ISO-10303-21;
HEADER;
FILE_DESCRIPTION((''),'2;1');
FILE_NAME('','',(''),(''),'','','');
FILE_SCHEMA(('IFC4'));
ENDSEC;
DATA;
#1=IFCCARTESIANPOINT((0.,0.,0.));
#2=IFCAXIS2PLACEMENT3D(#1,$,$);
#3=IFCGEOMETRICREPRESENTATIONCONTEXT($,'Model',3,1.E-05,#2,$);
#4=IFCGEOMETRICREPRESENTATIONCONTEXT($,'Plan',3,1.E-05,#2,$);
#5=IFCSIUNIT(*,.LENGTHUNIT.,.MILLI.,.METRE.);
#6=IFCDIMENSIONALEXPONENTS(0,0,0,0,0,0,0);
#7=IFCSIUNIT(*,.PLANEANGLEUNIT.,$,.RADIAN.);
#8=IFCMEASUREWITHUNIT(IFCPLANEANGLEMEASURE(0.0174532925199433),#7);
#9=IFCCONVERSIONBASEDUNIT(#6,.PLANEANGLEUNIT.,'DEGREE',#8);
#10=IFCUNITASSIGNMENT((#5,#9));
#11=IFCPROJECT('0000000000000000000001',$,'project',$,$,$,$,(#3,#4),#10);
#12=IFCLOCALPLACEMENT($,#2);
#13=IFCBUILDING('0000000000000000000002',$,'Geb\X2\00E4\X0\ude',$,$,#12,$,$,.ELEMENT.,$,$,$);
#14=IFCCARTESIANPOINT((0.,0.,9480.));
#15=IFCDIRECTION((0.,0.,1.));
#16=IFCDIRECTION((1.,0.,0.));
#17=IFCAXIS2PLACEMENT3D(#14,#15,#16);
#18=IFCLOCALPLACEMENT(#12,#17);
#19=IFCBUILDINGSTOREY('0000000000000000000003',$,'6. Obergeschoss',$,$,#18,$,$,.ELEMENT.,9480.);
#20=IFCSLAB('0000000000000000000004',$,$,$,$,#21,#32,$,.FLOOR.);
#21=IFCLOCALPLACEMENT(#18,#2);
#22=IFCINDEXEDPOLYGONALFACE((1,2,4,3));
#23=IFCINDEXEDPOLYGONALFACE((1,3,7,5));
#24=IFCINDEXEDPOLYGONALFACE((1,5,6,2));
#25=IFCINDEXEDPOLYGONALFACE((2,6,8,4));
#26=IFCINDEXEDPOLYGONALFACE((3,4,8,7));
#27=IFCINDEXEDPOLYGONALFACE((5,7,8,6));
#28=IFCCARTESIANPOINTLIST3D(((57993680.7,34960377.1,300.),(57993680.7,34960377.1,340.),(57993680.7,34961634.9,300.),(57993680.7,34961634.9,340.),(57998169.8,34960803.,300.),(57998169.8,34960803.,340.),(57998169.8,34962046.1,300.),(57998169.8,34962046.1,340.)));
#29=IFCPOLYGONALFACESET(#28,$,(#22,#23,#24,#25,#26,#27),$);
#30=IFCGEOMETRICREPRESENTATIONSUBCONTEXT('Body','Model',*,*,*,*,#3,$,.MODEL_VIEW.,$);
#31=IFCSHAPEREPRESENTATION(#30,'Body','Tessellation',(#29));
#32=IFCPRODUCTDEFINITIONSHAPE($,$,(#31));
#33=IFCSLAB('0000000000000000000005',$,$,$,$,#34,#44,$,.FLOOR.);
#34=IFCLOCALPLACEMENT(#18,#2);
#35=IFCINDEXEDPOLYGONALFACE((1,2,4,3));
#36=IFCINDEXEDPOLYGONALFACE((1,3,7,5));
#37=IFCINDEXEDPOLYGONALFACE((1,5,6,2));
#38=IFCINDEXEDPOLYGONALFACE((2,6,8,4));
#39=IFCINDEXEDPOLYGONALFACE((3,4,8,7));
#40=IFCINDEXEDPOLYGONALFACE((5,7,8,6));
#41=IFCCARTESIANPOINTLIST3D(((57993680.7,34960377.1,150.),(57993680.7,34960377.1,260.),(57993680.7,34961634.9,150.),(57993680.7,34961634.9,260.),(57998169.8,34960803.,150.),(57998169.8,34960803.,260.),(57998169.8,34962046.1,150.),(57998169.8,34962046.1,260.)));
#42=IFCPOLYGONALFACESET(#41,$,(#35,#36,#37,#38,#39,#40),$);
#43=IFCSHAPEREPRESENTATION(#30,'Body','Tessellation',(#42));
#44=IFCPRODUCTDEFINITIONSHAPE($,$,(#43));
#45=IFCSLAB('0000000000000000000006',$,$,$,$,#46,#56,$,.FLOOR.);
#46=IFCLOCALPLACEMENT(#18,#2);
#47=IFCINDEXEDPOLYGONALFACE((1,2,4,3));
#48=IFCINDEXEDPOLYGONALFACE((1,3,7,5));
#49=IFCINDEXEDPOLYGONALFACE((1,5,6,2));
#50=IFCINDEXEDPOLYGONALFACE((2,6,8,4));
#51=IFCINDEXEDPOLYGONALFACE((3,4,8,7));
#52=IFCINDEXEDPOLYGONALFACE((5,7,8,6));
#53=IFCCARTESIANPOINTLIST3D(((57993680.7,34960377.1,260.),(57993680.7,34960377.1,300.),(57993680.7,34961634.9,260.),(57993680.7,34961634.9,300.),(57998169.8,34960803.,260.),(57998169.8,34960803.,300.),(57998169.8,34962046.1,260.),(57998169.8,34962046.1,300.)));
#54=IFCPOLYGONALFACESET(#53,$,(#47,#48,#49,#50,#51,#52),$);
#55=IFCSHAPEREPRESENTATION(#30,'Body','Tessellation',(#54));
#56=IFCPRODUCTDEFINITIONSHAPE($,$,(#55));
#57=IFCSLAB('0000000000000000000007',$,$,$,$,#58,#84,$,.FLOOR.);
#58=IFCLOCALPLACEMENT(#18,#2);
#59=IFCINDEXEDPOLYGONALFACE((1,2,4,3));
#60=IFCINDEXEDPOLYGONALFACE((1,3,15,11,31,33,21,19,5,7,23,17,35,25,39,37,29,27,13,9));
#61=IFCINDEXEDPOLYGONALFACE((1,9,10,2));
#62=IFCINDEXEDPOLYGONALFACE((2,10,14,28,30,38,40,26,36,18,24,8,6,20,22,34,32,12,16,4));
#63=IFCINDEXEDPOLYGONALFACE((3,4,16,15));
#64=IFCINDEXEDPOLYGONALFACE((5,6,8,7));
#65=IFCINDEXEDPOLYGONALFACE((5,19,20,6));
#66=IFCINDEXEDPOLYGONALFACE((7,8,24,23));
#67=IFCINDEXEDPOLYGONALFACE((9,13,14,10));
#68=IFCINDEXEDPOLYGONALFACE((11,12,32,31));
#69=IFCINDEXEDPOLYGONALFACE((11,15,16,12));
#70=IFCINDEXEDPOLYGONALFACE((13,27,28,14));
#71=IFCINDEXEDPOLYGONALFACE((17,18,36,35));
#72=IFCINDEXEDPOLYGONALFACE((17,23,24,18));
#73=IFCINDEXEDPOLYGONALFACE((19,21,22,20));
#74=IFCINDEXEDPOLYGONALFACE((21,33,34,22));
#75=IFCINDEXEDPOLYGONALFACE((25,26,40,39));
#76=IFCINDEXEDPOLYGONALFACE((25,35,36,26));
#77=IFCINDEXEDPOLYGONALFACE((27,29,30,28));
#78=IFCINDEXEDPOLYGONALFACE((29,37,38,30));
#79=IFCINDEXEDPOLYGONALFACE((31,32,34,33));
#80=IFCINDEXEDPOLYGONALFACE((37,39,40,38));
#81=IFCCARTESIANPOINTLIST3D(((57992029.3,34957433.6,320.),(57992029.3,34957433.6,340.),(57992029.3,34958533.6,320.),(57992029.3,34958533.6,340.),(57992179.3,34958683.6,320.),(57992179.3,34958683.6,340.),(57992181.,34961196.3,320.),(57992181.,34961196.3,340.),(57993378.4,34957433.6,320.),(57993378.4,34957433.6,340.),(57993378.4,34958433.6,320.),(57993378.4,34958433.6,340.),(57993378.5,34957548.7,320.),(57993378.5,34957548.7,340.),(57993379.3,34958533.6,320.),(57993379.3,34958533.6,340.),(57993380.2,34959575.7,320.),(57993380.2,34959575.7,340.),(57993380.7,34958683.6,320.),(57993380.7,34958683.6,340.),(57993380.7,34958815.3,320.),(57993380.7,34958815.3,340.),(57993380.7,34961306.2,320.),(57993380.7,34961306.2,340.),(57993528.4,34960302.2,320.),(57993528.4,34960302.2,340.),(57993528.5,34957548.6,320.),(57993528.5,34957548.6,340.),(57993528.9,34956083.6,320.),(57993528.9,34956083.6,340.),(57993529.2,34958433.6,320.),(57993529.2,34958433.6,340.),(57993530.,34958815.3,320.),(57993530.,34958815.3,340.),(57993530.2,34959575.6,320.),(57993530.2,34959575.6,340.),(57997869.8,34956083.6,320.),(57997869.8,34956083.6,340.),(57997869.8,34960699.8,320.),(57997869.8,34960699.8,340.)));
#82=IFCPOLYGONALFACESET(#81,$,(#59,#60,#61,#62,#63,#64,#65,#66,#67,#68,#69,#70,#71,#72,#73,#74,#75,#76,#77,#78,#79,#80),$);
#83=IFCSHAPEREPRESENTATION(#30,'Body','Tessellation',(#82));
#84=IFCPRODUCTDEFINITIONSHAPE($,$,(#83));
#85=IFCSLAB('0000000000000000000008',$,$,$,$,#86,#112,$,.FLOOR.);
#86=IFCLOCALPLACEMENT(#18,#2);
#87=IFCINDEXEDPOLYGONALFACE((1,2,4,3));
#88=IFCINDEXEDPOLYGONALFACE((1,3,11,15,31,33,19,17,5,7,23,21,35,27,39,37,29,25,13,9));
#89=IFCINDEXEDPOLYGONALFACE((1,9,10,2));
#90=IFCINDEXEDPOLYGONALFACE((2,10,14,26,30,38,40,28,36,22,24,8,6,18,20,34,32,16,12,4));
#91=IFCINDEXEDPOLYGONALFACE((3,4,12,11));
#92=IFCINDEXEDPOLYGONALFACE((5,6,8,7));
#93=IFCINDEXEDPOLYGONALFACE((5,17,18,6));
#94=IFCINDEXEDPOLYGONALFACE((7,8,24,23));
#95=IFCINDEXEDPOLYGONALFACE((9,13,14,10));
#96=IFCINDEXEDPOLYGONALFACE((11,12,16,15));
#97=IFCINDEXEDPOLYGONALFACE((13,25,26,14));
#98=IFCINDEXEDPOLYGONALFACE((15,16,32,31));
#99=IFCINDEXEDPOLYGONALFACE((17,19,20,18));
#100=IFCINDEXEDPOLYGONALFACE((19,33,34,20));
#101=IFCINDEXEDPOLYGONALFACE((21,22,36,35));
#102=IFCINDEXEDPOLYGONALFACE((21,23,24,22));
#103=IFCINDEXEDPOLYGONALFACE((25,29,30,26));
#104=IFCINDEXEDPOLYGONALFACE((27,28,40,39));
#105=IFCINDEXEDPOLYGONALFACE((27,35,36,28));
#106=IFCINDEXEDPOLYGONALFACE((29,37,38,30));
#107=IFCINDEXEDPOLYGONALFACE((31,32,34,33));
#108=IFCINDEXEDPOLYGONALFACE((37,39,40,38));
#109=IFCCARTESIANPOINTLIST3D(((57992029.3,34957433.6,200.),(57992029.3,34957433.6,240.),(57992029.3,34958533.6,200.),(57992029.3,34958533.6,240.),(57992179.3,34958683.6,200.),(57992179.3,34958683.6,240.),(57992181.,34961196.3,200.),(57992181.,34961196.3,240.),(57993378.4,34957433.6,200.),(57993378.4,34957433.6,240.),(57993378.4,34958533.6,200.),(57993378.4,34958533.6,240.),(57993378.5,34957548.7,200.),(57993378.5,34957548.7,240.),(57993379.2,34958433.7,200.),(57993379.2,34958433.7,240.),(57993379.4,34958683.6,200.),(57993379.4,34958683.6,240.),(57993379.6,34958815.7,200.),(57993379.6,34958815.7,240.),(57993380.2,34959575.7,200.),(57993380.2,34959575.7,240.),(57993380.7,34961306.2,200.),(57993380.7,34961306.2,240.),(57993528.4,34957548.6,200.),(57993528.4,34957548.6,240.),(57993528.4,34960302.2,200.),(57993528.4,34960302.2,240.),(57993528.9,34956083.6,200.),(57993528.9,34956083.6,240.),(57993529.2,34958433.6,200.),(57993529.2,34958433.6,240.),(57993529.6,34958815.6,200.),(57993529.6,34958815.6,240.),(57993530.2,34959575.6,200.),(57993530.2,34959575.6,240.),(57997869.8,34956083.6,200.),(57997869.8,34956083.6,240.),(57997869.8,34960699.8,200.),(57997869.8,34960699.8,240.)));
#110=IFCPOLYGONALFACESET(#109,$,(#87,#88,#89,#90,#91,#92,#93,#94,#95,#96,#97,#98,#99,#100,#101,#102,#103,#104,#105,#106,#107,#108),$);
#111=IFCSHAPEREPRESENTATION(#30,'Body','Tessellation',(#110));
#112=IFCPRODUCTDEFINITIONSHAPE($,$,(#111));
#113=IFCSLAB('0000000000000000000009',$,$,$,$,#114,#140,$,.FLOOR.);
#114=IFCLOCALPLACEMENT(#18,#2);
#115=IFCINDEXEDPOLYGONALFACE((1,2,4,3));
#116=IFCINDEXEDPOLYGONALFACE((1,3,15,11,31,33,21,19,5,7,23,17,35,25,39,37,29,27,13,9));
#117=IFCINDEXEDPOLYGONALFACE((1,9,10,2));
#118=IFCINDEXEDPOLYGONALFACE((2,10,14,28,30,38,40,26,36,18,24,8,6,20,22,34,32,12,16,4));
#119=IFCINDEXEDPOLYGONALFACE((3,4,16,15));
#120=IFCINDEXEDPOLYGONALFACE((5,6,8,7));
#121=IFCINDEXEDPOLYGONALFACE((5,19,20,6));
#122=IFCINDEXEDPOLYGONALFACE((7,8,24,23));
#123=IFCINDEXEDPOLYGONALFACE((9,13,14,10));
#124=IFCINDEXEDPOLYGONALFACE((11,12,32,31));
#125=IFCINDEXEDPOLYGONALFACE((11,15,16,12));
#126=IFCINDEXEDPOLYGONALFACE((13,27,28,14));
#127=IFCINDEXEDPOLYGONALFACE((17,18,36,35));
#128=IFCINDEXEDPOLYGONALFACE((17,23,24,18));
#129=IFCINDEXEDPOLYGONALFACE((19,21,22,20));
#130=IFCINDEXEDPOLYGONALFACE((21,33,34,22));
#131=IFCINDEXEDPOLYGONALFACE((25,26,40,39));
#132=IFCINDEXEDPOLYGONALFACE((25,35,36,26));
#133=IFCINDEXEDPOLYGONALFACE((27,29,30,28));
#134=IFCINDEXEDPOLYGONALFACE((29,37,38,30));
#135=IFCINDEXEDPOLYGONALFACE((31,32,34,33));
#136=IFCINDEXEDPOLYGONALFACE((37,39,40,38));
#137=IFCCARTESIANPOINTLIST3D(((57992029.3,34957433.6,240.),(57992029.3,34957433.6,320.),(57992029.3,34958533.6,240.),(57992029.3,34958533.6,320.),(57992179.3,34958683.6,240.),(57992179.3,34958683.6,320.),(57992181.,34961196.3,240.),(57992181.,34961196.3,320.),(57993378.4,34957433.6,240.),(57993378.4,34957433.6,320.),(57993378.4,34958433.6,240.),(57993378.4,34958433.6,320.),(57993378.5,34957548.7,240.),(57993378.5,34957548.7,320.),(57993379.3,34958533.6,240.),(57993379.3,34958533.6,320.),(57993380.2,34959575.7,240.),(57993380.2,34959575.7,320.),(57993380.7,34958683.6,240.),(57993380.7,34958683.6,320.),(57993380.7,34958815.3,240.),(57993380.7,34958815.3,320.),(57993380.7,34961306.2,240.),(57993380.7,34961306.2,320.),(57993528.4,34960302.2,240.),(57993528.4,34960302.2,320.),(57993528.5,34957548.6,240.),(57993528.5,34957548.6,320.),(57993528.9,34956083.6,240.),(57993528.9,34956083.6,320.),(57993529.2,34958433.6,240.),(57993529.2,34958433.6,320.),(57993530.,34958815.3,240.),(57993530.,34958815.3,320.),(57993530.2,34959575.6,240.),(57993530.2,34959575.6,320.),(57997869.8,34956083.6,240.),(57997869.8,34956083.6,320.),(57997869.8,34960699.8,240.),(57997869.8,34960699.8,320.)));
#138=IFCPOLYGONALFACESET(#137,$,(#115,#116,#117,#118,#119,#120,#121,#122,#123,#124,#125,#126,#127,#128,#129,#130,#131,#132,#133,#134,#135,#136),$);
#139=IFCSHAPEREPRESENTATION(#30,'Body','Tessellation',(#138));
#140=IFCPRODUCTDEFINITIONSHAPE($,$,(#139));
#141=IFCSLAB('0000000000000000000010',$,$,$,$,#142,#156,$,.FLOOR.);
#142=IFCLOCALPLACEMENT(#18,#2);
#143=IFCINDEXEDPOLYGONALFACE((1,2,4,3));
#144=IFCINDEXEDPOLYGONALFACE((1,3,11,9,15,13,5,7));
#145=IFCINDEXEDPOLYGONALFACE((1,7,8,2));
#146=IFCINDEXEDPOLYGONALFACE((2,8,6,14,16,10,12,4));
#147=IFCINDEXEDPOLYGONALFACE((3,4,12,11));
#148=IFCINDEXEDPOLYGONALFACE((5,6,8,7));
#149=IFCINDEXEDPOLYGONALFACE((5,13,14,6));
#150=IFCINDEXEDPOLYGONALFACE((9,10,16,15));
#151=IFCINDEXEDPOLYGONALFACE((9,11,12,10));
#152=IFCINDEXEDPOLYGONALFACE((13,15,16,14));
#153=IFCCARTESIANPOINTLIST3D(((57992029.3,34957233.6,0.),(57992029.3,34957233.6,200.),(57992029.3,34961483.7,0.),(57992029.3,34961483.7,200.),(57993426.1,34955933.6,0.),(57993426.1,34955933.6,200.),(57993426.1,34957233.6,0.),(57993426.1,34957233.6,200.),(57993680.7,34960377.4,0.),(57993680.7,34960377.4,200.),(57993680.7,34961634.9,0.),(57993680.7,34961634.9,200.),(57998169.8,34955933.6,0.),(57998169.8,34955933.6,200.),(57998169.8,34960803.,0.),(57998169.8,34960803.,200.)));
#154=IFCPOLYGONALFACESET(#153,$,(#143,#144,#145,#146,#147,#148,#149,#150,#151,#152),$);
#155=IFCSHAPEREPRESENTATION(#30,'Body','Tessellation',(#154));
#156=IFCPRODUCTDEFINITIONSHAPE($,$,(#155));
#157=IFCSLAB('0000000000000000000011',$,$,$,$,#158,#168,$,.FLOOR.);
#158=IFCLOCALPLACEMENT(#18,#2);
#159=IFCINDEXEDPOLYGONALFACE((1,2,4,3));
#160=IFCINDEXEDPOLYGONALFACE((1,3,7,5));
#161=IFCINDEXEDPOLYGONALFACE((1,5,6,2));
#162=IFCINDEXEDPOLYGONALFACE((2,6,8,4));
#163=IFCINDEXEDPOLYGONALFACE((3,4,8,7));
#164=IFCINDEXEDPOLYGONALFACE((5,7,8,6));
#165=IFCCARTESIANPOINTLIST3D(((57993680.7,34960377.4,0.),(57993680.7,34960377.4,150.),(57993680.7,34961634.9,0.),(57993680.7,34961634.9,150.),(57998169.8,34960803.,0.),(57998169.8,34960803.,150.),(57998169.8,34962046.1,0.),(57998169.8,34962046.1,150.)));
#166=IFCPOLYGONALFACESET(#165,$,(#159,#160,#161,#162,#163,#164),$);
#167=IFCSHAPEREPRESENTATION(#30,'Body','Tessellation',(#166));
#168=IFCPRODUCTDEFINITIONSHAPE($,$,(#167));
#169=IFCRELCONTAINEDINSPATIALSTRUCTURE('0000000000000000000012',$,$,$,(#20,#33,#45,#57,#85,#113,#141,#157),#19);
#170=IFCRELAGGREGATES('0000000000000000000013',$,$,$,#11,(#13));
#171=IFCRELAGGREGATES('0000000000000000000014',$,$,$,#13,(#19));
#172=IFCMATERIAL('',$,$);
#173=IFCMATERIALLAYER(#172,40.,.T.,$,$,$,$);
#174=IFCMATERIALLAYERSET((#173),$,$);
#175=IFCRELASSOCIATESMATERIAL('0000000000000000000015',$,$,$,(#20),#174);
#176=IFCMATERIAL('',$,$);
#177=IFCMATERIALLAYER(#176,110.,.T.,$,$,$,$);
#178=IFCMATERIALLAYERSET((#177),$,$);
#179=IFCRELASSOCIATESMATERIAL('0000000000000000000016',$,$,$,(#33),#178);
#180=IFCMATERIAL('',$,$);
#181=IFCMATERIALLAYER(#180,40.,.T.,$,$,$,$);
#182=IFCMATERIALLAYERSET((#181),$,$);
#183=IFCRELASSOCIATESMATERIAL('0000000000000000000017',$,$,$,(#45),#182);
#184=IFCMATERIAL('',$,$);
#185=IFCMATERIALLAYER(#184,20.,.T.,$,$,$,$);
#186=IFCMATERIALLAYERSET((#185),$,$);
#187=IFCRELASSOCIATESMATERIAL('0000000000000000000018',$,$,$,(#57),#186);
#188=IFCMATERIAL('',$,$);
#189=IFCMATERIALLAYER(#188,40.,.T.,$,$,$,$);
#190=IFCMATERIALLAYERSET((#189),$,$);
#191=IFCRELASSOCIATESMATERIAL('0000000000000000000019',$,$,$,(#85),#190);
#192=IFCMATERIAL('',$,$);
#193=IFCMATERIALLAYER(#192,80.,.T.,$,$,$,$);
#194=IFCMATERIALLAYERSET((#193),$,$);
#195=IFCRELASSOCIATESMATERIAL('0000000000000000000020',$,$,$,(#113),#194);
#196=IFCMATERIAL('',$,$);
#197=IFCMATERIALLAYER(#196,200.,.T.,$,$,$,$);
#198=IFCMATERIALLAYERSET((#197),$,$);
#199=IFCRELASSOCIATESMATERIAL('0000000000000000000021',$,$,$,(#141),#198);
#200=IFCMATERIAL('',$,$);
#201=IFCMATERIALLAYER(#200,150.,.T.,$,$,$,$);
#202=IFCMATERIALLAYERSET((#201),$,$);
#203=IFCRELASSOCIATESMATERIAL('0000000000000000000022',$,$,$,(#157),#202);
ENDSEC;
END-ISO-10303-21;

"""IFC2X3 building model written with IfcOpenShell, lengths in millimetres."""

from ifc_helpers import new_model, entity, si_unit, converted_unit, frame, origin, origin_with_axes, place, context, subcontext, project, spatial, polyline, outline, extrude, material, layer, layer_set, layer_usage, element, save


model = new_model("IFC2X3")

# Units and contexts
model_context = context("Model", 3, precision=1e-05, world=origin())
plan_context = context("Plan", 3, precision=1e-05, world=origin())
body_context = subcontext(model_context, "Body", "Model", "MODEL_VIEW")
ifc_project = project(units=[si_unit("LENGTHUNIT", "METRE", prefix="MILLI"), converted_unit("PLANEANGLEUNIT", "DEGREE", entity("IfcPlaneAngleMeasure", 0.0174532925199433), si_unit("PLANEANGLEUNIT", "RADIAN"), dimensions=[0, 0, 0, 0, 0, 0, 0])], contexts=[model_context, plan_context])

# Building, storey
building_placement = place(None, origin())
building = spatial("IfcBuilding", under=ifc_project, at=building_placement, Name="Gebäude", CompositionType="ELEMENT")
storey_placement = place(building_placement, frame((0.0, 0.0, 9480.0), z_axis=(0.0, 0.0, 1.0), x_axis=(1.0, 0.0, 0.0)))
storey = spatial("IfcBuildingStorey", under=building, at=storey_placement, Name="6. Obergeschoss", CompositionType="ELEMENT", Elevation=9480.0)

# Slabs
ifc_material_1 = material(Name="")
ifc_layer_1 = layer(ifc_material_1, 40.0, ventilated=True)
ifc_layer_set_1 = layer_set([ifc_layer_1])
ifc_layer_usage_1 = layer_usage(ifc_layer_set_1, "AXIS3", "POSITIVE", 0.0)
slab_1_placement = place(storey_placement, frame((57993680.7, 34960377.1, 300.0), z_axis=(0.0, 0.0, 1.0), x_axis=(1.0, 0.0, 0.0)))
element("IfcSlab", 1, at=slab_1_placement, inside=storey, material=ifc_layer_usage_1, PredefinedType="FLOOR", context=body_context, shape_type="SweptSolid", body=[
    extrude(outline(polyline([(0.0, 0.0), (4489.1, 425.9), (4489.1, 1669.0), (0.0, 1257.9), (0.0, 0.0)])), origin_with_axes(), (0.0, 0.0, 1.0), 40.0),
])
ifc_material_2 = material(Name="")
ifc_layer_2 = layer(ifc_material_2, 110.0, ventilated=True)
ifc_layer_set_2 = layer_set([ifc_layer_2])
ifc_layer_usage_2 = layer_usage(ifc_layer_set_2, "AXIS3", "POSITIVE", 0.0)
slab_2_placement = place(storey_placement, frame((57993680.7, 34960377.1, 150.0), z_axis=(0.0, 0.0, 1.0), x_axis=(1.0, 0.0, 0.0)))
element("IfcSlab", 2, at=slab_2_placement, inside=storey, material=ifc_layer_usage_2, PredefinedType="FLOOR", context=body_context, shape_type="SweptSolid", body=[
    extrude(outline(polyline([(0.0, 0.0), (4489.1, 425.9), (4489.1, 1669.0), (0.0, 1257.9), (0.0, 0.0)])), origin_with_axes(), (0.0, 0.0, 1.0), 110.0),
])
ifc_material_3 = material(Name="")
ifc_layer_3 = layer(ifc_material_3, 40.0, ventilated=True)
ifc_layer_set_3 = layer_set([ifc_layer_3])
ifc_layer_usage_3 = layer_usage(ifc_layer_set_3, "AXIS3", "POSITIVE", 0.0)
slab_3_placement = place(storey_placement, frame((57993680.7, 34960377.1, 260.0), z_axis=(0.0, 0.0, 1.0), x_axis=(1.0, 0.0, 0.0)))
element("IfcSlab", 3, at=slab_3_placement, inside=storey, material=ifc_layer_usage_3, PredefinedType="FLOOR", context=body_context, shape_type="SweptSolid", body=[
    extrude(outline(polyline([(0.0, 0.0), (4489.1, 425.9), (4489.1, 1669.0), (0.0, 1257.9), (0.0, 0.0)])), origin_with_axes(), (0.0, 0.0, 1.0), 40.0),
])
ifc_material_4 = material(Name="")
ifc_layer_4 = layer(ifc_material_4, 20.0, ventilated=True)
ifc_layer_set_4 = layer_set([ifc_layer_4])
ifc_layer_usage_4 = layer_usage(ifc_layer_set_4, "AXIS3", "POSITIVE", 0.0)
slab_4_placement = place(storey_placement, frame((57992029.3, 34956083.6, 320.0), z_axis=(0.0, 0.0, 1.0), x_axis=(1.0, 0.0, 0.0)))
element("IfcSlab", 4, at=slab_4_placement, inside=storey, material=ifc_layer_usage_4, PredefinedType="FLOOR", context=body_context, shape_type="SweptSolid", body=[
    extrude(outline(polyline([(0.0, 1350.0), (1349.1, 1350.0), (1349.2, 1465.1), (1499.2, 1465.0), (1499.6, 0.0), (5840.5, 0.0), (5840.5, 4616.2), (1499.1, 4218.6), (1500.8, 3492.0), (1350.8, 3492.1), (1351.4, 5222.6), (151.7, 5112.7), (150.0, 2600.0), (1351.4, 2600.0), (1351.4, 2731.7), (1500.7, 2731.7), (1499.9, 2350.0), (1349.1, 2350.0), (1350.0, 2450.0), (0.0, 2450.0), (0.0, 1350.0)])), origin_with_axes(), (0.0, 0.0, 1.0), 20.0),
])
ifc_material_5 = material(Name="")
ifc_layer_5 = layer(ifc_material_5, 40.0, ventilated=True)
ifc_layer_set_5 = layer_set([ifc_layer_5])
ifc_layer_usage_5 = layer_usage(ifc_layer_set_5, "AXIS3", "POSITIVE", 0.0)
slab_5_placement = place(storey_placement, frame((57992029.3, 34956083.6, 200.0), z_axis=(0.0, 0.0, 1.0), x_axis=(1.0, 0.0, 0.0)))
element("IfcSlab", 5, at=slab_5_placement, inside=storey, material=ifc_layer_usage_5, PredefinedType="FLOOR", context=body_context, shape_type="SweptSolid", body=[
    extrude(outline(polyline([(0.0, 1350.0), (1349.1, 1350.0), (1349.2, 1465.1), (1499.1, 1465.0), (1499.6, 0.0), (5840.5, 0.0), (5840.5, 4616.2), (1499.1, 4218.6), (1500.8, 3492.0), (1350.8, 3492.1), (1351.4, 5222.6), (151.7, 5112.7), (150.0, 2600.0), (1350.1, 2600.0), (1350.2, 2732.1), (1500.2, 2732.0), (1499.9, 2350.0), (1349.9, 2350.1), (1349.1, 2450.0), (0.0, 2450.0), (0.0, 1350.0)])), origin_with_axes(), (0.0, 0.0, 1.0), 40.0),
])
ifc_material_6 = material(Name="")
ifc_layer_6 = layer(ifc_material_6, 80.0, ventilated=True)
ifc_layer_set_6 = layer_set([ifc_layer_6])
ifc_layer_usage_6 = layer_usage(ifc_layer_set_6, "AXIS3", "POSITIVE", 0.0)
slab_6_placement = place(storey_placement, frame((57992029.3, 34956083.6, 240.0), z_axis=(0.0, 0.0, 1.0), x_axis=(1.0, 0.0, 0.0)))
element("IfcSlab", 6, at=slab_6_placement, inside=storey, material=ifc_layer_usage_6, PredefinedType="FLOOR", context=body_context, shape_type="SweptSolid", body=[
    extrude(outline(polyline([(0.0, 1350.0), (1349.1, 1350.0), (1349.2, 1465.1), (1499.2, 1465.0), (1499.6, 0.0), (5840.5, 0.0), (5840.5, 4616.2), (1499.1, 4218.6), (1500.8, 3492.0), (1350.8, 3492.1), (1351.4, 5222.6), (151.7, 5112.7), (150.0, 2600.0), (1351.4, 2600.0), (1351.4, 2731.7), (1500.7, 2731.7), (1499.9, 2350.0), (1349.1, 2350.0), (1350.0, 2450.0), (0.0, 2450.0), (0.0, 1350.0)])), origin_with_axes(), (0.0, 0.0, 1.0), 80.0),
])
ifc_material_7 = material(Name="")
ifc_layer_7 = layer(ifc_material_7, 200.0, ventilated=True)
ifc_layer_set_7 = layer_set([ifc_layer_7])
ifc_layer_usage_7 = layer_usage(ifc_layer_set_7, "AXIS3", "POSITIVE", 0.0)
slab_7_placement = place(storey_placement, frame((57992029.3, 34955933.6, 0.0), z_axis=(0.0, 0.0, 1.0), x_axis=(1.0, 0.0, 0.0)))
element("IfcSlab", 7, at=slab_7_placement, inside=storey, material=ifc_layer_usage_7, PredefinedType="FLOOR", context=body_context, shape_type="SweptSolid", body=[
    extrude(outline(polyline([(6140.5, 4869.4), (1651.4, 4443.8), (1651.4, 5701.4), (0.0, 5550.1), (0.0, 1300.0), (1396.7, 1300.0), (1396.7, 0.0), (6140.5, 0.0), (6140.5, 4869.4)])), origin_with_axes(), (0.0, 0.0, 1.0), 200.0),
])
ifc_material_8 = material(Name="")
ifc_layer_8 = layer(ifc_material_8, 150.0, ventilated=True)
ifc_layer_set_8 = layer_set([ifc_layer_8])
ifc_layer_usage_8 = layer_usage(ifc_layer_set_8, "AXIS3", "POSITIVE", 0.0)
slab_8_placement = place(storey_placement, frame((57993680.7, 34960377.4, 0.0), z_axis=(0.0, 0.0, 1.0), x_axis=(1.0, 0.0, 0.0)))
element("IfcSlab", 8, at=slab_8_placement, inside=storey, material=ifc_layer_usage_8, PredefinedType="FLOOR", context=body_context, shape_type="SweptSolid", body=[
    extrude(outline(polyline([(0.0, 0.0), (4489.1, 425.6), (4489.1, 1668.7), (0.0, 1257.6), (0.0, 0.0)])), origin_with_axes(), (0.0, 0.0, 1.0), 150.0),
])

save(model, "model.ifc")
